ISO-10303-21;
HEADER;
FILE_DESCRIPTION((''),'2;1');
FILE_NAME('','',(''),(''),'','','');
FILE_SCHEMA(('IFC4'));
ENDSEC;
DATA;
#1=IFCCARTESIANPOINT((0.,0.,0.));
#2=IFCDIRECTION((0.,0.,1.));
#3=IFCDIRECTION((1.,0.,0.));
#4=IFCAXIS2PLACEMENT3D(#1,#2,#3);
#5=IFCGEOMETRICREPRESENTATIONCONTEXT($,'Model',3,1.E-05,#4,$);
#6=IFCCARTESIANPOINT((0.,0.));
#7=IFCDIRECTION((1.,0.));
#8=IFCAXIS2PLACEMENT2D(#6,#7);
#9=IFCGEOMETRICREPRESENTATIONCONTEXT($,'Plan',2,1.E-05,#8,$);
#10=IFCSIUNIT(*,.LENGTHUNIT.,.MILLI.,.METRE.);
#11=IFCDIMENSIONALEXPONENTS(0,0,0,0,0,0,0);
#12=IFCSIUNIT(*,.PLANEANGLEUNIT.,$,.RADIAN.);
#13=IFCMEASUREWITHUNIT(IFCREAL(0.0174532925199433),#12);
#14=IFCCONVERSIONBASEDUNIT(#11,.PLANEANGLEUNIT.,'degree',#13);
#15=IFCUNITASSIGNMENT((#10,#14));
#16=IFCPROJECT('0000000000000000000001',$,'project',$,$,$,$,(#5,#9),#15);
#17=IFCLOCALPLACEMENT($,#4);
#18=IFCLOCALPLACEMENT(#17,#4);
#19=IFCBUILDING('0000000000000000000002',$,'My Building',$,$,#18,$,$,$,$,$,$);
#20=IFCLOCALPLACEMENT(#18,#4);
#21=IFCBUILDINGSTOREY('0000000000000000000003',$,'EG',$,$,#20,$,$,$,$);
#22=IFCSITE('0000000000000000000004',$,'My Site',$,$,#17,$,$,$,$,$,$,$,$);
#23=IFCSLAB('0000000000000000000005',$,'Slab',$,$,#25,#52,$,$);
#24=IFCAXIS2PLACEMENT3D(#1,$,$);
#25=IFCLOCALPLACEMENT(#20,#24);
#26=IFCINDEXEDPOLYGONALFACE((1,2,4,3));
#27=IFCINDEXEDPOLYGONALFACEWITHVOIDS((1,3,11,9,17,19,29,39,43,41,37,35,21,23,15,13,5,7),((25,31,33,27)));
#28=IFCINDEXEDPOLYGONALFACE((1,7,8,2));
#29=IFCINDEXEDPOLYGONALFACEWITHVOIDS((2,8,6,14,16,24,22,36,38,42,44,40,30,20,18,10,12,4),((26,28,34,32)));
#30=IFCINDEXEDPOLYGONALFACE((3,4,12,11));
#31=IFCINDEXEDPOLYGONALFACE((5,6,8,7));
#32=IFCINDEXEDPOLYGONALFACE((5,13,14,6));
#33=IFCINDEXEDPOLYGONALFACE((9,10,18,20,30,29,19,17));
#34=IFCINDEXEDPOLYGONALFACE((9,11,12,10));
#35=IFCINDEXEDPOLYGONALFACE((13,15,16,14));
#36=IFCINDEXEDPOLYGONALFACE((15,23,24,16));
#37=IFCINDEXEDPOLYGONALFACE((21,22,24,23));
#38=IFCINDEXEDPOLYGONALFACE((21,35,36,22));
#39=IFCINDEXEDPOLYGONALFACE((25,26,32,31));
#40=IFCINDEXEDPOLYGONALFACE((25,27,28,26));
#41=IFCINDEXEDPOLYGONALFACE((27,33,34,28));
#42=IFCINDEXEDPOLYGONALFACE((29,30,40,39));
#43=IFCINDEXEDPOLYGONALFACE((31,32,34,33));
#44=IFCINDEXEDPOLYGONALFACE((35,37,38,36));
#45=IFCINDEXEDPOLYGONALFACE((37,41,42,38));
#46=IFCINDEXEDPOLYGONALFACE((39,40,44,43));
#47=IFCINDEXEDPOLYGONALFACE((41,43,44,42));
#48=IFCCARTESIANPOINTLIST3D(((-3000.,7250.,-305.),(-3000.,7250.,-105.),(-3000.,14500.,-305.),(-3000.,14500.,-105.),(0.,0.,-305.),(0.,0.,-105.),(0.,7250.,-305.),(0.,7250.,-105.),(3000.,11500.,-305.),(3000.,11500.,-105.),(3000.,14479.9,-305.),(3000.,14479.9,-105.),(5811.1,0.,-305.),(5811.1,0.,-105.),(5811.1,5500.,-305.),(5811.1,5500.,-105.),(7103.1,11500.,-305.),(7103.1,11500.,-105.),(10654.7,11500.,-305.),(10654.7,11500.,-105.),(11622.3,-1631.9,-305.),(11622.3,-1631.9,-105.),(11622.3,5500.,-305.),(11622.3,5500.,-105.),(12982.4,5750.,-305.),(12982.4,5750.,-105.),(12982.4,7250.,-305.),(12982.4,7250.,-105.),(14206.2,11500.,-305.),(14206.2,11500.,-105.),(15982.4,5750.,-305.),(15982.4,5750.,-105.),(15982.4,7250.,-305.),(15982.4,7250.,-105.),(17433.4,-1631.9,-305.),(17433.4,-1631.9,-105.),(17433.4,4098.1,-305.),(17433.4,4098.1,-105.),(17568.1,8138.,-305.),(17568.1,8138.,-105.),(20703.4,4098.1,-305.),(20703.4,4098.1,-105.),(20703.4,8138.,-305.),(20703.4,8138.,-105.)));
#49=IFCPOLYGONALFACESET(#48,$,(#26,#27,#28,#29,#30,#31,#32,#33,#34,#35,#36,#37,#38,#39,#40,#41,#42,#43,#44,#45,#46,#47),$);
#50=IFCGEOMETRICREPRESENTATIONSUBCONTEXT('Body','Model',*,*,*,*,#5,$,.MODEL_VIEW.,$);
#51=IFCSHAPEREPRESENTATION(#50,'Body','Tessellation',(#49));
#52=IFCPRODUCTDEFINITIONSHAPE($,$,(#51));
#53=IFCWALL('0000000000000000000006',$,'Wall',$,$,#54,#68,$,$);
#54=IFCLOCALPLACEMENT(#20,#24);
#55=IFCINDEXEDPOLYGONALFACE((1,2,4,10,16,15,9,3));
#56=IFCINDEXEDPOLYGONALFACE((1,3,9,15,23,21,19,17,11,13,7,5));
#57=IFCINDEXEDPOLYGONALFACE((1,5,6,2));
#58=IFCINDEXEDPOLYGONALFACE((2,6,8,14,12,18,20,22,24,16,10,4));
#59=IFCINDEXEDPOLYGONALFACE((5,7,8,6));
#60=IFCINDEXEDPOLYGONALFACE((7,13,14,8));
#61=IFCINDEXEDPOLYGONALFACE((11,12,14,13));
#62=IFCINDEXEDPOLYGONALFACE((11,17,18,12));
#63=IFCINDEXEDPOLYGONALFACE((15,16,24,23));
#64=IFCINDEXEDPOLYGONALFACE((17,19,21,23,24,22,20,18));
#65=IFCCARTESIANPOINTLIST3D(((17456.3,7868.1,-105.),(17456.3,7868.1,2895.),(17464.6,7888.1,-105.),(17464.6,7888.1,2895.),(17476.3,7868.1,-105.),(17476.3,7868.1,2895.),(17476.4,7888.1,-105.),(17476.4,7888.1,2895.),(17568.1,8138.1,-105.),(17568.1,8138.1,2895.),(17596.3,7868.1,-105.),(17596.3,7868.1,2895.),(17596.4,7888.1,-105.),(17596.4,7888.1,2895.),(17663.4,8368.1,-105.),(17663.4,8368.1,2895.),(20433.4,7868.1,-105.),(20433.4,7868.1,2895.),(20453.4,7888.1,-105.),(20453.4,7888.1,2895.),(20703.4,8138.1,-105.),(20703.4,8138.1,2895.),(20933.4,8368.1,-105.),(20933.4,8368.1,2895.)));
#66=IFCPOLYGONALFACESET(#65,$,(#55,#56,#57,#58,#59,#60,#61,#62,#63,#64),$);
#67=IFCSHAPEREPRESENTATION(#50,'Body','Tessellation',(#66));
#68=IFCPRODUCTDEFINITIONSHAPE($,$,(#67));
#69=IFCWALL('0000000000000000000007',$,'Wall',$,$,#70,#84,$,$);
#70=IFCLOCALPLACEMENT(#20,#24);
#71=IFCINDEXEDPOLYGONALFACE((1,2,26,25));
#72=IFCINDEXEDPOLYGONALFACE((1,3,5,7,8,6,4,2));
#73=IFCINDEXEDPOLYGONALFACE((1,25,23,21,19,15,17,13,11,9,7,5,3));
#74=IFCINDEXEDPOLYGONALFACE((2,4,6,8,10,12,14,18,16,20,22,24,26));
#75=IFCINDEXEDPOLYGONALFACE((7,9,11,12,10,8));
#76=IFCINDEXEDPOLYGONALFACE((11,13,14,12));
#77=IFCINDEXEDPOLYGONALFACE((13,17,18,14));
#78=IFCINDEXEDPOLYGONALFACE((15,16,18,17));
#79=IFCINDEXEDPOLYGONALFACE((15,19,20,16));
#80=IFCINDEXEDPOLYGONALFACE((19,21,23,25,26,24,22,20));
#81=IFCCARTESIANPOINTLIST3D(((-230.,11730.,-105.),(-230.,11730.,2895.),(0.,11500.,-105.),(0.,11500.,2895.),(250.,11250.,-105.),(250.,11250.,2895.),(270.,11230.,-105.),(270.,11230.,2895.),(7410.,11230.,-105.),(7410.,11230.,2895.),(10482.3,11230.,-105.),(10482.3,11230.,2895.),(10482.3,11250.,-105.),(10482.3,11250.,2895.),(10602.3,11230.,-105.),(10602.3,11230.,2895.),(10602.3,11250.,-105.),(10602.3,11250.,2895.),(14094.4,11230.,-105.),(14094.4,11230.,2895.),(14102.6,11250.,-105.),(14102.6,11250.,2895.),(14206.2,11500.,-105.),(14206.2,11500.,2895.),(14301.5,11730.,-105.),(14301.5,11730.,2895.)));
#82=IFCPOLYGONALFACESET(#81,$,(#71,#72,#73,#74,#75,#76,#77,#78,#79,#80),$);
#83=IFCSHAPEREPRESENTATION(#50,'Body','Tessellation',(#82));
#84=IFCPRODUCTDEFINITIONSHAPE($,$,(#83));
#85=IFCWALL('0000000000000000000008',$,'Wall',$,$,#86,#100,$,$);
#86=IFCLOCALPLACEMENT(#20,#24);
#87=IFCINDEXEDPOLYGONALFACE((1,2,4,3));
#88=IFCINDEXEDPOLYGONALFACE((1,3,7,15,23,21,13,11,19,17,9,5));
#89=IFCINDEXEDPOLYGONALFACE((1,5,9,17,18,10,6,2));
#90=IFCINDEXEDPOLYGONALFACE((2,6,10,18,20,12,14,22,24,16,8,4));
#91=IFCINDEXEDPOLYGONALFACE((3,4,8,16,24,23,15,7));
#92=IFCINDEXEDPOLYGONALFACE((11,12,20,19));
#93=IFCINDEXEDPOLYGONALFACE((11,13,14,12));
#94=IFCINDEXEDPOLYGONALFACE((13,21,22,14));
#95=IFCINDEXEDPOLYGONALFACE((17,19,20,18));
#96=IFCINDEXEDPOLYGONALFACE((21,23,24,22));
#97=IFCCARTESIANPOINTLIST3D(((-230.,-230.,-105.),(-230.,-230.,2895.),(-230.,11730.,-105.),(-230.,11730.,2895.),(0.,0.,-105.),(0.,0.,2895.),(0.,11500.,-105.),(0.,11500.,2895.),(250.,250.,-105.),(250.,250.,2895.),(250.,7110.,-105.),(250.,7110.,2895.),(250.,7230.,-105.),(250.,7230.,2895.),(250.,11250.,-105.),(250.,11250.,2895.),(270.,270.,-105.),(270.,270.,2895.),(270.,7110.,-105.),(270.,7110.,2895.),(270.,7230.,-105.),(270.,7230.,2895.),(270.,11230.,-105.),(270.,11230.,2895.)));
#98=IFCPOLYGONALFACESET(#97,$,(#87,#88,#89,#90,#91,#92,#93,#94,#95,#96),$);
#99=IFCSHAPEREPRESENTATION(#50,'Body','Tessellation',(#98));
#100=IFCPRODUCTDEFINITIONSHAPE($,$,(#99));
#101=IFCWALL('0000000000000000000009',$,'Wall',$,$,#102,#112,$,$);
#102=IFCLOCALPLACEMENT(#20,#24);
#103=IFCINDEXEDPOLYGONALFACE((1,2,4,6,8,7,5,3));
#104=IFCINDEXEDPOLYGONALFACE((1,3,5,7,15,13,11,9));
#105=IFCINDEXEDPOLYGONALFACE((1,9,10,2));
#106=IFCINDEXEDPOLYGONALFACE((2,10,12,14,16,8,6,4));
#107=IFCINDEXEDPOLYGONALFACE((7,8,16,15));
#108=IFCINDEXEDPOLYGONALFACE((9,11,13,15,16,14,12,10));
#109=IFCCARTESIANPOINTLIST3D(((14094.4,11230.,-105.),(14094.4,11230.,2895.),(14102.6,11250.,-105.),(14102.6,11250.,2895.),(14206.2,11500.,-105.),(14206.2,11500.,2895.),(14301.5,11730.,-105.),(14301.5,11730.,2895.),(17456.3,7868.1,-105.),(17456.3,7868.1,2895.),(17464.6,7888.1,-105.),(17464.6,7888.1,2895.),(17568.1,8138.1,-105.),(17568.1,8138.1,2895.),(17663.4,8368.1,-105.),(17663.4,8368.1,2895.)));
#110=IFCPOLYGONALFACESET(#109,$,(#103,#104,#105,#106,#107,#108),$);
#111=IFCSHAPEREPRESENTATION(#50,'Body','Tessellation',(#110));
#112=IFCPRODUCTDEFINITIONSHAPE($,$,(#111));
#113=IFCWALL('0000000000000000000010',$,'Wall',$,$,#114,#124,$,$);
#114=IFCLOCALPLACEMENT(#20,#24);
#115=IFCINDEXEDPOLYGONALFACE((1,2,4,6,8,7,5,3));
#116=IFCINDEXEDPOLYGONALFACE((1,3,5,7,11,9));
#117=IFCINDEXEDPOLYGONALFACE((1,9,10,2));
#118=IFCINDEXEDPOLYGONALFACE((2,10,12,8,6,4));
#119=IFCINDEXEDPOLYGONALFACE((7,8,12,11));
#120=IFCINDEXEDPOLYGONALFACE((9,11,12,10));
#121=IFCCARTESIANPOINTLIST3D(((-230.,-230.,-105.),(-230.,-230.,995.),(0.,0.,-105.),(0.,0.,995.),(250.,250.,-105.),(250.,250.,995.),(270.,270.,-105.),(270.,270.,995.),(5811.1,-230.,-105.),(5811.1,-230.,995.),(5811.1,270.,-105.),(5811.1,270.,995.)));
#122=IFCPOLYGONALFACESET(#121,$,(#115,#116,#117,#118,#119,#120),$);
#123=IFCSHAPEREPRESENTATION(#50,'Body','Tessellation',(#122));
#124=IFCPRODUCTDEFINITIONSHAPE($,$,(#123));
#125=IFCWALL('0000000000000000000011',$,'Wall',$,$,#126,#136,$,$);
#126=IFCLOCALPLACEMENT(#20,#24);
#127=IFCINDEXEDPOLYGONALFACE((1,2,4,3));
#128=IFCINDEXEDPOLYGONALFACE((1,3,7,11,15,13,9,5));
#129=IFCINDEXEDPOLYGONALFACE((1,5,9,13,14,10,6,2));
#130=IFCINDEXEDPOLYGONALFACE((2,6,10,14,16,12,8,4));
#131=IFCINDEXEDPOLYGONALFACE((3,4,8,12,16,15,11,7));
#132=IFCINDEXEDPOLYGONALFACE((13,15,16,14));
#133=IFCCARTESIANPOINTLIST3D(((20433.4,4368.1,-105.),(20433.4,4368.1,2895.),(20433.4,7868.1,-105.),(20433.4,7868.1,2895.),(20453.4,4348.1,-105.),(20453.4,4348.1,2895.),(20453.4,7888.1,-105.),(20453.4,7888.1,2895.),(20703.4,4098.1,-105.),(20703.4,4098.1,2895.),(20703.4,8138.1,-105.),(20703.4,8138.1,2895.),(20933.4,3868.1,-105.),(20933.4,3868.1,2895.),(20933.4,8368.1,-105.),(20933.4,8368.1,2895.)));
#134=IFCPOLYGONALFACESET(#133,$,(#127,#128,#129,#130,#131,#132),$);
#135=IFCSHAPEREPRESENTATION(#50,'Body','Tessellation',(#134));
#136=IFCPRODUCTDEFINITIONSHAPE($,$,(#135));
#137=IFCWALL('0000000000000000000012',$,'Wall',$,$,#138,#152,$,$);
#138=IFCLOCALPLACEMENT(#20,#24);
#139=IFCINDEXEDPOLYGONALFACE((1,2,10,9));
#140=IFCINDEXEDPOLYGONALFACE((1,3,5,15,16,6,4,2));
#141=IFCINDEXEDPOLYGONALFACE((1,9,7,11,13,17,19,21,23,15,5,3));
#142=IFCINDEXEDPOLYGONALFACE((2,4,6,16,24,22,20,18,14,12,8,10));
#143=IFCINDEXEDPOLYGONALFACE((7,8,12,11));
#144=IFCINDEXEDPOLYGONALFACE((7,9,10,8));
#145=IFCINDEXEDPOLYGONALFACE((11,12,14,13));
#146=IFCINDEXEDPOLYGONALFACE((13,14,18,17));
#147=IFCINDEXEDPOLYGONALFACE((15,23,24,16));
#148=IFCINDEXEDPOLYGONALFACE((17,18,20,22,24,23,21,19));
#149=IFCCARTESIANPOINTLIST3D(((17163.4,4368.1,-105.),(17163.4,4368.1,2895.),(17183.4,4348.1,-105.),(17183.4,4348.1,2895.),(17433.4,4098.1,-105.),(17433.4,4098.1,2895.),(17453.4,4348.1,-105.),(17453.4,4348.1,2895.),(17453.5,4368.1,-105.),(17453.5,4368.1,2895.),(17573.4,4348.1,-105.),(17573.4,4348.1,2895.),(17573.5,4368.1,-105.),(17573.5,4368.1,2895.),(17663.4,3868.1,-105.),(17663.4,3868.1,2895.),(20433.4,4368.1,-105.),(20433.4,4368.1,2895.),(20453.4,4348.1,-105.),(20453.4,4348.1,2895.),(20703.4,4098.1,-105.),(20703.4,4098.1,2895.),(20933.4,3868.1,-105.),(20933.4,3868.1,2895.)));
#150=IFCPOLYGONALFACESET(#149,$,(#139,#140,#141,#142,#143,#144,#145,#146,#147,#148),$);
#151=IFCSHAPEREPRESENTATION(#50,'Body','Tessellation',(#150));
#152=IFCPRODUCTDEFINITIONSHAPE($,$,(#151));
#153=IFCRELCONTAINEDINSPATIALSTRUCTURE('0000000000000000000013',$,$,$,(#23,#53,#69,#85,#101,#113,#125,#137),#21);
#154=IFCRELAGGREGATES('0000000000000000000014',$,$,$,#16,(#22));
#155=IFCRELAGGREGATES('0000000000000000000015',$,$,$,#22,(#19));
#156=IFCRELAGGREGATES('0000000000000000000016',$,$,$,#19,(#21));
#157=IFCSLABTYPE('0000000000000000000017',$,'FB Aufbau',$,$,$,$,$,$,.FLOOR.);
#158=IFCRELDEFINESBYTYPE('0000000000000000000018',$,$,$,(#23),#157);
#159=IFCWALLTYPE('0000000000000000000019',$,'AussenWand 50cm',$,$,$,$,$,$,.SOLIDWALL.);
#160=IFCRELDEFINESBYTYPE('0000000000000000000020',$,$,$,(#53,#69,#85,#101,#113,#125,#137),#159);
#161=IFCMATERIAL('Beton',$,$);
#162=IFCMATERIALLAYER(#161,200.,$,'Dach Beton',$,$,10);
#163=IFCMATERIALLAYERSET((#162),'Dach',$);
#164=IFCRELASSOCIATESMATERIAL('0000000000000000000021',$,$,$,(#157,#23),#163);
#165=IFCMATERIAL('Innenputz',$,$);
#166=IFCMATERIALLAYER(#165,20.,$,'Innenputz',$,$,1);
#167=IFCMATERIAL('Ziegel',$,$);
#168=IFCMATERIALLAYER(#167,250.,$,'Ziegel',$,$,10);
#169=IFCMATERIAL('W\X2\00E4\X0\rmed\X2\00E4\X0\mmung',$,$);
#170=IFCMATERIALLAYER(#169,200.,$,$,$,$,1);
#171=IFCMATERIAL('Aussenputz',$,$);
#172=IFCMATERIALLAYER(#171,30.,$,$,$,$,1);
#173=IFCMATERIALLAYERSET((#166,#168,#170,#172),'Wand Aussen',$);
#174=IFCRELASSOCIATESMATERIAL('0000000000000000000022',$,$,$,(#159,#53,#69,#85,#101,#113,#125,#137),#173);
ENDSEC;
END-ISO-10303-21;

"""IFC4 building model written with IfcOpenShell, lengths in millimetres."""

from ifc_helpers import new_model, entity, si_unit, converted_unit, frame, origin_with_axes, origin_2d_with_axis, place, context, subcontext, project, spatial, line, indexed_curve, outline, extrude, material, layer, layer_set, layer_usage, type_object, element, save


model = new_model("IFC4")

# Units and contexts
model_context = context("Model", 3, precision=1e-05, world=origin_with_axes())
plan_context = context("Plan", 2, precision=1e-05, world=origin_2d_with_axis())
body_context = subcontext(model_context, "Body", "Model", "MODEL_VIEW")
ifc_project = project(units=[si_unit("LENGTHUNIT", "METRE", prefix="MILLI"), converted_unit("PLANEANGLEUNIT", "degree", entity("IfcReal", 0.0174532925199433), si_unit("PLANEANGLEUNIT", "RADIAN"), dimensions=[0, 0, 0, 0, 0, 0, 0])], contexts=[model_context, plan_context])

# Site, building, storey
site_placement = place(None, origin_with_axes())
site = spatial("IfcSite", under=ifc_project, at=site_placement, Name="My Site")
building_placement = place(site_placement, origin_with_axes())
building = spatial("IfcBuilding", under=site, at=building_placement, Name="My Building")
storey_placement = place(building_placement, origin_with_axes())
storey = spatial("IfcBuildingStorey", under=building, at=storey_placement, Name="EG")

# Slab
ifc_material_1 = material(Name="Beton")
ifc_layer_1 = layer(ifc_material_1, 200.0, Name="Dach Beton", Priority=10)
ifc_layer_set_1 = layer_set([ifc_layer_1], Name="Dach")
ifc_layer_usage_1 = layer_usage(ifc_layer_set_1, "AXIS3", "POSITIVE", 0.0)
slab_type = type_object("IfcSlabType", Name="FB Aufbau", PredefinedType="FLOOR", material=ifc_layer_set_1)
slab_1_placement = place(storey_placement, frame((0.0, 0.0, -305.0), z_axis=(0.0, 0.0, 1.0), x_axis=(1.0, 0.0, 0.0)))
element("IfcSlab", 1, at=slab_1_placement, inside=storey, type_object=slab_type, material=ifc_layer_usage_1, Name="Slab", context=body_context, shape_type="SweptSolid", body=[
    extrude(outline(indexed_curve([(3000.0, 11500.0), (3000.0, 14479.9), (-3000.0, 14500.0), (-3000.0, 7250.0), (0.0, 7250.0), (0.0, 0.0), (5811.1, 0.0), (5811.1, 5500.0), (11622.3, 5500.0), (11622.3, -1631.9), (17433.4, -1631.9), (17433.4, 4098.1), (20703.4, 4098.1), (20703.4, 8138.0), (17568.1, 8138.0), (14206.2, 11500.0), (10654.7, 11500.0), (7103.1, 11500.0), (3000.0, 11500.0)]), holes=[indexed_curve([(12982.4, 5750.0), (12982.4, 7250.0), (15982.4, 7250.0), (15982.4, 5750.0), (12982.4, 5750.0)])]), origin_with_axes(), (0.0, 0.0, 1.0), 200.0),
])

# Walls
ifc_material_2 = material(Name="Innenputz")
ifc_layer_2 = layer(ifc_material_2, 20.0, Name="Innenputz", Priority=1)
ifc_material_3 = material(Name="Ziegel")
ifc_layer_3 = layer(ifc_material_3, 250.0, Name="Ziegel", Priority=10)
ifc_material_4 = material(Name="Wärmedämmung")
ifc_layer_4 = layer(ifc_material_4, 200.0, Priority=1)
ifc_material_5 = material(Name="Aussenputz")
ifc_layer_5 = layer(ifc_material_5, 30.0, Priority=1)
ifc_layer_set_2 = layer_set([ifc_layer_2, ifc_layer_3, ifc_layer_4, ifc_layer_5], Name="Wand Aussen")
ifc_layer_usage_2 = layer_usage(ifc_layer_set_2, "AXIS2", "POSITIVE", 0.0)
wall_type_1 = type_object("IfcWallType", Name="AussenWand 50cm", PredefinedType="SOLIDWALL", material=ifc_layer_set_2)
wall_1_placement = place(storey_placement, frame((17456.3, 7868.1, -105.0), z_axis=(0.0, 0.0, 1.0), x_axis=(1.0, 0.0, 0.0)))
element("IfcWall", 2, at=wall_1_placement, inside=storey, type_object=wall_type_1, material=ifc_layer_usage_2, Name="Wall", context=body_context, shape_type="SweptSolid", body=[
    extrude(outline(indexed_curve([(0.0, 0.0), (8.3, 20.0), (111.8, 270.0), (207.1, 500.0), (3477.1, 500.0), (3247.1, 270.0), (2997.1, 20.0), (2977.1, 0.0), (140.0, 0.0), (140.1, 20.0), (20.1, 20.0), (20.0, 0.0)], segments=[line(1, 2, 3, 4, 5, 6, 7, 8, 9, 10, 11, 12, 1)])), origin_with_axes(), (0.0, 0.0, 1.0), 3000.0),
])
ifc_layer_usage_3 = layer_usage(ifc_layer_set_2, "AXIS2", "NEGATIVE", 0.0)
wall_2_placement = place(storey_placement, frame((14094.4, 11230.0, -105.0), z_axis=(0.0, 0.0, 1.0), x_axis=(-1.0, 0.0, 0.0)))
element("IfcWall", 3, at=wall_2_placement, inside=storey, type_object=wall_type_1, material=ifc_layer_usage_3, Name="Wall", context=body_context, shape_type="SweptSolid", body=[
    extrude(outline(indexed_curve([(-207.1, -500.0), (-111.8, -270.0), (-8.3, -20.0), (0.0, 0.0), (3492.1, 0.0), (3492.1, -20.0), (3612.1, -20.0), (3612.1, 0.0), (9804.4, 0.0), (9804.4, -20.0), (9684.4, -20.0), (9684.4, 0.0), (6804.4, 0.0), (6804.4, -20.0), (6684.4, -20.0), (6684.4, 0.0), (13824.4, 0.0), (13844.4, -20.0), (14094.4, -270.0), (14324.4, -500.0)], segments=[line(1, 2, 3, 4, 5, 6, 7, 8, 9, 10, 11, 12, 13, 14, 15, 16, 17, 18, 19, 20, 1)])), origin_with_axes(), (0.0, 0.0, 1.0), 3000.0),
])
ifc_layer_usage_4 = layer_usage(ifc_layer_set_2, "AXIS2", "NEGATIVE", 0.0, extent=0.0)
wall_3_placement = place(storey_placement, frame((270.0, 11230.0, -105.0), z_axis=(0.0, 0.0, 1.0), x_axis=(0.0, -1.0, 0.0)))
element("IfcWall", 4, at=wall_3_placement, inside=storey, type_object=wall_type_1, material=ifc_layer_usage_4, Name="Wall", context=body_context, shape_type="SweptSolid", body=[
    extrude(outline(indexed_curve([(-500.0, -500.0), (-270.0, -270.0), (-20.0, -20.0), (0.0, 0.0), (4000.0, 0.0), (4000.0, -20.0), (4120.0, -20.0), (4120.0, 0.0), (10960.0, 0.0), (10980.0, -20.0), (11230.0, -270.0), (11460.0, -500.0)], segments=[line(1, 2, 3, 4, 5, 6, 7, 8, 9, 10, 11, 12, 1)])), origin_with_axes(), (0.0, 0.0, 1.0), 3000.0),
])
ifc_layer_usage_5 = layer_usage(ifc_layer_set_2, "AXIS2", "NEGATIVE", 0.0)
wall_4_placement = place(storey_placement, frame((17456.3, 7868.1, -105.0), z_axis=(0.0, 0.0, 1.0), x_axis=(-0.707107, 0.707107, 0.0)))
element("IfcWall", 5, at=wall_4_placement, inside=storey, type_object=wall_type_1, material=ifc_layer_usage_5, Name="Wall", context=body_context, shape_type="SweptSolid", body=[
    extrude(outline(indexed_curve([(207.1, -500.0), (111.8, -270.0), (8.3, -20.0), (0.0, 0.0), (4754.5, 0.0), (4762.8, -20.0), (4866.3, -270.0), (4961.6, -500.0)], segments=[line(1, 2, 3, 4, 5, 6, 7, 8, 1)])), origin_with_axes(), (0.0, 0.0, 1.0), 3000.0),
])
ifc_layer_usage_6 = layer_usage(ifc_layer_set_2, "AXIS2", "NEGATIVE", 0.0)
wall_5_placement = place(storey_placement, frame((270.0, 270.0, -105.0), z_axis=(0.0, 0.0, 1.0), x_axis=(1.0, 0.0, 0.0)))
element("IfcWall", 6, at=wall_5_placement, inside=storey, type_object=wall_type_1, material=ifc_layer_usage_6, Name="Wall", context=body_context, shape_type="SweptSolid", body=[
    extrude(outline(indexed_curve([(-500.0, -500.0), (-270.0, -270.0), (-20.0, -20.0), (0.0, 0.0), (5541.1, 0.0), (5541.1, -500.0)], segments=[line(1, 2, 3, 4, 5, 6, 1)])), origin_with_axes(), (0.0, 0.0, 1.0), 1100.0),
])
ifc_layer_usage_7 = layer_usage(ifc_layer_set_2, "AXIS2", "POSITIVE", 0.0)
wall_6_placement = place(storey_placement, frame((20433.4, 7868.1, -105.0), z_axis=(0.0, 0.0, 1.0), x_axis=(0.0, -1.0, 0.0)))
element("IfcWall", 7, at=wall_6_placement, inside=storey, type_object=wall_type_1, material=ifc_layer_usage_7, Name="Wall", context=body_context, shape_type="SweptSolid", body=[
    extrude(outline(indexed_curve([(0.0, 0.0), (-20.0, 20.0), (-270.0, 270.0), (-500.0, 500.0), (4000.0, 500.0), (3770.0, 270.0), (3520.0, 20.0), (3500.0, 0.0)], segments=[line(1, 2, 3, 4, 5, 6, 7, 8, 1)])), origin_with_axes(), (0.0, 0.0, 1.0), 3000.0),
])
ifc_layer_usage_8 = layer_usage(ifc_layer_set_2, "AXIS2", "POSITIVE", 0.0)
wall_7_placement = place(storey_placement, frame((20433.4, 4368.1, -105.0), z_axis=(0.0, 0.0, 1.0), x_axis=(-1.0, 0.0, 0.0)))
element("IfcWall", 8, at=wall_7_placement, inside=storey, type_object=wall_type_1, material=ifc_layer_usage_8, Name="Wall", context=body_context, shape_type="SweptSolid", body=[
    extrude(outline(indexed_curve([(0.0, 0.0), (-20.0, 20.0), (-270.0, 270.0), (-500.0, 500.0), (2770.0, 500.0), (3000.0, 270.0), (3250.0, 20.0), (3270.0, 0.0), (2979.9, 0.0), (2980.0, 20.0), (2860.0, 20.0), (2859.9, 0.0)], segments=[line(1, 2, 3, 4, 5, 6, 7, 8, 9, 10, 11, 12, 1)])), origin_with_axes(), (0.0, 0.0, 1.0), 3000.0),
])

save(model, "model.ifc")
